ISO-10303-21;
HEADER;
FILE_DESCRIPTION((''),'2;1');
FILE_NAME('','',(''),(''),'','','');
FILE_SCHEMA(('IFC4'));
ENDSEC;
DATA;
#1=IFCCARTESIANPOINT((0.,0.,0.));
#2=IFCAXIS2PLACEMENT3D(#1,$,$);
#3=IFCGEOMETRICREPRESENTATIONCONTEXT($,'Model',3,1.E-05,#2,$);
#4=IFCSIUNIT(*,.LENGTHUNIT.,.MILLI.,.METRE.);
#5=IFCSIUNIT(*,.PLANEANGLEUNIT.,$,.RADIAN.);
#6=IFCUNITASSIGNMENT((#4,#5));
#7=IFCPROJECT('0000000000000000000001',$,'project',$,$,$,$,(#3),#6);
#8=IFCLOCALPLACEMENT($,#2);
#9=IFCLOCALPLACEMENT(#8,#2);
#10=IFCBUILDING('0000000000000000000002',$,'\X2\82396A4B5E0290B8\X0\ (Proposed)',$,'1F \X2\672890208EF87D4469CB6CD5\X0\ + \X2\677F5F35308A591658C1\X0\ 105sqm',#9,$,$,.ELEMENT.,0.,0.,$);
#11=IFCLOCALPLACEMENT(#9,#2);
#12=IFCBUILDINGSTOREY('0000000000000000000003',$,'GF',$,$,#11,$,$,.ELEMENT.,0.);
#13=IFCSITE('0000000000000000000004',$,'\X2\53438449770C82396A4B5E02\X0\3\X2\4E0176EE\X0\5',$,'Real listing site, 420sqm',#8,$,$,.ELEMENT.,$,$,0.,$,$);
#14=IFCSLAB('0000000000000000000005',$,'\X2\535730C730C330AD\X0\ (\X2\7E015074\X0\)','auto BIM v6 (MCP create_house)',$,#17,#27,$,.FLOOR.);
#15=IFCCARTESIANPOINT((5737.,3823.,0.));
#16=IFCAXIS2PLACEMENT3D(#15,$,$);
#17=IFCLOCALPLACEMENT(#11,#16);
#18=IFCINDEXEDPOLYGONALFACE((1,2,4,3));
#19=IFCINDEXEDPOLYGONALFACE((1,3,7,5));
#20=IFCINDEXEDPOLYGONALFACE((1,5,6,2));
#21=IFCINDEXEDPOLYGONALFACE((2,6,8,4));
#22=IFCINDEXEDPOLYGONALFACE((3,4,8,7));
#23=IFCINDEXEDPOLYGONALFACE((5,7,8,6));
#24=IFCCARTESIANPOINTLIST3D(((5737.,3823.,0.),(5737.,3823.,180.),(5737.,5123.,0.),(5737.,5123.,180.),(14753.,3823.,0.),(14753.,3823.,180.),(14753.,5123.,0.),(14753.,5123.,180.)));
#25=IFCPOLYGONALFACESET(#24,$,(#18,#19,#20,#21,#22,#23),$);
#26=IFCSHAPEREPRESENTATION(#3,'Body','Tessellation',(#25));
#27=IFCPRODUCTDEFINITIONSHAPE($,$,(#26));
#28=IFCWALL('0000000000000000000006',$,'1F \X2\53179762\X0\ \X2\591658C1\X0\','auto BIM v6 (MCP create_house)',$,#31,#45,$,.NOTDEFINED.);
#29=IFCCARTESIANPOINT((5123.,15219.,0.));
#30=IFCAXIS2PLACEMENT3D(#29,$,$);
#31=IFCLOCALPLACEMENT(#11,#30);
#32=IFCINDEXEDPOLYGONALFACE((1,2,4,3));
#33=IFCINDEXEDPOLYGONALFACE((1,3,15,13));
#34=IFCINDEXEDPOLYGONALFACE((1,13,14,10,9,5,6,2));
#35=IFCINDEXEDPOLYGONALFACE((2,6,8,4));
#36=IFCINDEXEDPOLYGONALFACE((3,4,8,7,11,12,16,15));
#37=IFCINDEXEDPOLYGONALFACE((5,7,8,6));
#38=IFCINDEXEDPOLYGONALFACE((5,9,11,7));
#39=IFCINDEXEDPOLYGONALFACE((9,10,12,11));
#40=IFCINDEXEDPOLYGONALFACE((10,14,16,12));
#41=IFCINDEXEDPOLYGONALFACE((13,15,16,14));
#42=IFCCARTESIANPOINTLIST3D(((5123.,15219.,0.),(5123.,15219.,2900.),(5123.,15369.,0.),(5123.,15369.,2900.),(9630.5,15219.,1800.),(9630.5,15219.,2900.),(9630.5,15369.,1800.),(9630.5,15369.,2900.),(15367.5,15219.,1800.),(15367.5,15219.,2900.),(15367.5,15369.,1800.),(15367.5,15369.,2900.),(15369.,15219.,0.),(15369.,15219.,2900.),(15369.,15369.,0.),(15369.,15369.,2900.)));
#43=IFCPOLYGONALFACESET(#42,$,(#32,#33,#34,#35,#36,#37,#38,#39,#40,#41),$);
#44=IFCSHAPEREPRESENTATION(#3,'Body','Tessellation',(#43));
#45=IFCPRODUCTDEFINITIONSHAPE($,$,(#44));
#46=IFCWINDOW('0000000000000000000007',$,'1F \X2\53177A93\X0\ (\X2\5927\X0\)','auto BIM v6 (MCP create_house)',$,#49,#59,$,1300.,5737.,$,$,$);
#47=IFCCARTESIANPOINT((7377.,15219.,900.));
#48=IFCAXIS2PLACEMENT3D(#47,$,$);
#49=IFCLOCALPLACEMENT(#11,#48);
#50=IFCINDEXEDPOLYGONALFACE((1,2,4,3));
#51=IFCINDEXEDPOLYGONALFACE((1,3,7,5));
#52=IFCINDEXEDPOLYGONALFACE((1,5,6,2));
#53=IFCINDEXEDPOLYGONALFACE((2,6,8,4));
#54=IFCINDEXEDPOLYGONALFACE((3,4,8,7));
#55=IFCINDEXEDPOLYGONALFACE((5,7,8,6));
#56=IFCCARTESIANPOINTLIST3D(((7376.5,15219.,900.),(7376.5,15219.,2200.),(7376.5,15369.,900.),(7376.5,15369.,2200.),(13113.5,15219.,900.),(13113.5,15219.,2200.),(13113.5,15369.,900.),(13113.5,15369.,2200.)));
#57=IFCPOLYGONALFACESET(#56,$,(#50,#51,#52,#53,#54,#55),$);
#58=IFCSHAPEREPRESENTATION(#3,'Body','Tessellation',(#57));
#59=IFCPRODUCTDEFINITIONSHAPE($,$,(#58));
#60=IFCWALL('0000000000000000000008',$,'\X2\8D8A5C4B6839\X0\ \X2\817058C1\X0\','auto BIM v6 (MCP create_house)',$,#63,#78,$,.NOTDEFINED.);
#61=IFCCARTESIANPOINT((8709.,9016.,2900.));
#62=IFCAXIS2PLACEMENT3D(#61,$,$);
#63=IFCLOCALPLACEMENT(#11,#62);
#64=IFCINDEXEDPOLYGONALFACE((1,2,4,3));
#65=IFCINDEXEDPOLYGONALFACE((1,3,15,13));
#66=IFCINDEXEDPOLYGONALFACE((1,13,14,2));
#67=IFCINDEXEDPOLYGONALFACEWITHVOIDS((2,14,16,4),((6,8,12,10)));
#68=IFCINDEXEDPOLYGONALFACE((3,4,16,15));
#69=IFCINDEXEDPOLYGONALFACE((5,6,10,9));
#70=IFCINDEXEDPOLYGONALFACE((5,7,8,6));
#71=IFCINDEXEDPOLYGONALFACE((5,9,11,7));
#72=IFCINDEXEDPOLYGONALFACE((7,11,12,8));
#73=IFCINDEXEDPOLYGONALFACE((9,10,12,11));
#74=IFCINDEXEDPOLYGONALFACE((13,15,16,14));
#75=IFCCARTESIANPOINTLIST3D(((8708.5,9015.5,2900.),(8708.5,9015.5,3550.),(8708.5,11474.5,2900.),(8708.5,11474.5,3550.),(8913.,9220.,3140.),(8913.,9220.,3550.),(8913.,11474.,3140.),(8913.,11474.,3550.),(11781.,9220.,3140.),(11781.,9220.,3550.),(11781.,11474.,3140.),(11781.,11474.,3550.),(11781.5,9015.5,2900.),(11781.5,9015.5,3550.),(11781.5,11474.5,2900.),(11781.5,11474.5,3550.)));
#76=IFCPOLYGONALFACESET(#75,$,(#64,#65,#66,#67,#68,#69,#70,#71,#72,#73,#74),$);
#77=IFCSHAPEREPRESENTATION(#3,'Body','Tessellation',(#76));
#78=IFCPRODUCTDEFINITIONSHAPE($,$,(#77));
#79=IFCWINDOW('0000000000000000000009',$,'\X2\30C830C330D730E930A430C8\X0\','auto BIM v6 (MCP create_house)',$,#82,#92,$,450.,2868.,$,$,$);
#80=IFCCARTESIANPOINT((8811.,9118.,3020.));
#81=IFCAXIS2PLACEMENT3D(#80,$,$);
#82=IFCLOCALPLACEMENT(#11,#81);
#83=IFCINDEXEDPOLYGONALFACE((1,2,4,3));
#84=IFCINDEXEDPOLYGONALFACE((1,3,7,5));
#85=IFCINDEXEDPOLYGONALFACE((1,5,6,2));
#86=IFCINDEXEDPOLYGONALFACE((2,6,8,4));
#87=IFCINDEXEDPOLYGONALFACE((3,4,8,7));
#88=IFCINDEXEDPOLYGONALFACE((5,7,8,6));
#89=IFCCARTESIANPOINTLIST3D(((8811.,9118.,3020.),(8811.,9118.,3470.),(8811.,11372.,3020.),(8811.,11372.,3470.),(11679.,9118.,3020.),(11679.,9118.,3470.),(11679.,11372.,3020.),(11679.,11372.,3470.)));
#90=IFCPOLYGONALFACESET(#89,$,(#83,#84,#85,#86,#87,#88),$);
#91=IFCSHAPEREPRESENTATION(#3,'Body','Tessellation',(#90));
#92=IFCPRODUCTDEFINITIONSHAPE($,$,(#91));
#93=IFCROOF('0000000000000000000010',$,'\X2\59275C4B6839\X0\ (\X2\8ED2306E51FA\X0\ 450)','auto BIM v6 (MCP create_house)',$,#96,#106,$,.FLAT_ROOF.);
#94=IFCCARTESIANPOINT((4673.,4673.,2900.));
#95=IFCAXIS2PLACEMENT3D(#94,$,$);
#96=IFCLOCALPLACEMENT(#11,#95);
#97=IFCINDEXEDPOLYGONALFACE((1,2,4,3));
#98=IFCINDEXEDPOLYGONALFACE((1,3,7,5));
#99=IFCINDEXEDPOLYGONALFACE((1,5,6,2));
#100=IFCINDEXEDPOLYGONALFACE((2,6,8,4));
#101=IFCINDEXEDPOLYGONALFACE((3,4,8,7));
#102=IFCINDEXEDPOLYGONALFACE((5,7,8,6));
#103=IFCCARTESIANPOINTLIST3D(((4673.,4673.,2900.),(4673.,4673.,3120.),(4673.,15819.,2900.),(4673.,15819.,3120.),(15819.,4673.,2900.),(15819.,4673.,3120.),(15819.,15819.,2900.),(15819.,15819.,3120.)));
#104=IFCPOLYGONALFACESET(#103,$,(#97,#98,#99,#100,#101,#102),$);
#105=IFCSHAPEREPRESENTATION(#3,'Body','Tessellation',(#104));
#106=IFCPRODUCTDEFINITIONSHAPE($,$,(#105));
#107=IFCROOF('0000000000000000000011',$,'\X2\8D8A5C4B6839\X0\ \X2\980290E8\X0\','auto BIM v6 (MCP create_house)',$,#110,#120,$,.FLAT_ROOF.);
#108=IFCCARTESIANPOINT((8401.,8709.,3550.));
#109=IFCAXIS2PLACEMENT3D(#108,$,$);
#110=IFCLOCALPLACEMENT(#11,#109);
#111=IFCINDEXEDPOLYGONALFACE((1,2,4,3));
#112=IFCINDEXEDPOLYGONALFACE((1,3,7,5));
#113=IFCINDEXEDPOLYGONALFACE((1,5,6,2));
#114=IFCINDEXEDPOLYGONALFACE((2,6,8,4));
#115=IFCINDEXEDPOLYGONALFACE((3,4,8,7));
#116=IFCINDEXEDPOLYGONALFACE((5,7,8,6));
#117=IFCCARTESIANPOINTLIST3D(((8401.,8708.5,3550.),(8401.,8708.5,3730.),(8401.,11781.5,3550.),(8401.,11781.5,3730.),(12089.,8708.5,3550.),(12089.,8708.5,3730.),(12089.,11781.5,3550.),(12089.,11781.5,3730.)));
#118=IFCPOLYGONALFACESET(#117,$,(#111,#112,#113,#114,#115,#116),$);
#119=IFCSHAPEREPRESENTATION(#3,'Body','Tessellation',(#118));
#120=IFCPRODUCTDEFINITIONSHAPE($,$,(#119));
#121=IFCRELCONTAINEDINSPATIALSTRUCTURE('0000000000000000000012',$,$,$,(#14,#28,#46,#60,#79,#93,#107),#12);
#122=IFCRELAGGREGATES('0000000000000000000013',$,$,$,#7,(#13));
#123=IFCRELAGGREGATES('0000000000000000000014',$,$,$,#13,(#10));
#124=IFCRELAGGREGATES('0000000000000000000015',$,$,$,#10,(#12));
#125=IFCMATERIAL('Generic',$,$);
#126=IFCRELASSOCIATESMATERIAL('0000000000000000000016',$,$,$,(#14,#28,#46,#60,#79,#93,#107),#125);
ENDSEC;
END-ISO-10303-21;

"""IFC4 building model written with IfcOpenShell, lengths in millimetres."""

from ifc_helpers import new_model, si_unit, frame, frame_2d, origin, place, context, project, spatial, rectangle, extrude, material, element, fill, save


model = new_model("IFC4")

# Units and contexts
model_context = context("Model", 3, precision=1e-05, world=origin())
ifc_project = project(units=[si_unit("LENGTHUNIT", "METRE", prefix="MILLI"), si_unit("PLANEANGLEUNIT", "RADIAN")], contexts=[model_context])

# Site, building, storey
site_placement = place(None, origin())
site = spatial("IfcSite", under=ifc_project, at=site_placement, Name="千葉県船橋市3丁目5", ObjectType="Real listing site, 420sqm", CompositionType="ELEMENT", RefElevation=0.0)
building_placement = place(site_placement, origin())
building = spatial("IfcBuilding", under=site, at=building_placement, Name="船橋市邸 (Proposed)", ObjectType="1F 木造軸組構法 + 板張り外壁 105sqm", CompositionType="ELEMENT", ElevationOfRefHeight=0.0, ElevationOfTerrain=0.0)
storey_placement = place(building_placement, origin())
storey = spatial("IfcBuildingStorey", under=building, at=storey_placement, Name="GF", CompositionType="ELEMENT", Elevation=0.0)

# Slab
ifc_material = material(Name="Generic")
slab_1_placement = place(storey_placement, frame((5737.0, 3823.0, 0.0)))
element("IfcSlab", 1, at=slab_1_placement, inside=storey, material=ifc_material, Name="南デッキ (縁側)", Description="auto BIM v6 (MCP create_house)", PredefinedType="FLOOR", context=model_context, shape_type="SweptSolid", body=[
    extrude(rectangle(XDim=9016.0, YDim=1300.0, at=frame_2d((4508.0, 650.0))), frame((5737.0, 3823.0, 0.0)), (0.0, 0.0, 1.0), 180.0),
])

# Wall, opening, window
wall_1_placement = place(storey_placement, frame((5123.0, 15219.0, 0.0)))
wall_1 = element("IfcWall", 2, at=wall_1_placement, inside=storey, material=ifc_material, Name="1F 北面 外壁", Description="auto BIM v6 (MCP create_house)", PredefinedType="NOTDEFINED", context=model_context, shape_type="SweptSolid", body=[
    extrude(rectangle(XDim=10246.0, YDim=150.0, at=frame_2d((5123.0, 75.0))), frame((5123.0, 15219.0, 0.0)), (0.0, 0.0, 1.0), 2900.0),
])
opening_1_placement = place(storey_placement, frame((7377.0, 15219.0, 900.0)))
opening_1 = element("IfcOpeningElement", 3, at=opening_1_placement, cuts=wall_1, PredefinedType="NOTDEFINED", context=model_context, shape_type="SweptSolid", body=[
    extrude(rectangle(XDim=5737.0, YDim=150.0, at=frame_2d((2868.0, 75.0))), frame((7377.0, 15219.0, 900.0)), (0.0, 0.0, 1.0), 1300.0),
])
window_1_placement = place(storey_placement, frame((7377.0, 15219.0, 900.0)))
window_1 = element("IfcWindow", 4, at=window_1_placement, inside=storey, material=ifc_material, Name="1F 北窓 (大)", Description="auto BIM v6 (MCP create_house)", OverallHeight=1300.0, OverallWidth=5737.0, context=model_context, shape_type="SweptSolid", body=[
    extrude(rectangle(XDim=5737.0, YDim=150.0, at=frame_2d((2868.0, 75.0))), frame((7377.0, 15219.0, 900.0)), (0.0, 0.0, 1.0), 1300.0),
])
fill(opening_1, window_1)

# Wall, opening, window
wall_2_placement = place(storey_placement, frame((8709.0, 9016.0, 2900.0)))
wall_2 = element("IfcWall", 5, at=wall_2_placement, inside=storey, material=ifc_material, Name="越屋根 腰壁", Description="auto BIM v6 (MCP create_house)", PredefinedType="NOTDEFINED", context=model_context, shape_type="SweptSolid", body=[
    extrude(rectangle(XDim=3073.0, YDim=2459.0, at=frame_2d((1536.0, 1229.0))), frame((8709.0, 9016.0, 2900.0)), (0.0, 0.0, 1.0), 650.0),
])
opening_2_placement = place(storey_placement, frame((8811.0, 9118.0, 3020.0)))
opening_2 = element("IfcOpeningElement", 6, at=opening_2_placement, cuts=wall_2, PredefinedType="NOTDEFINED", context=model_context, shape_type="SweptSolid", body=[
    extrude(rectangle(XDim=2868.0, YDim=2254.0, at=frame_2d((1434.0, 1127.0))), frame((8811.0, 9118.0, 3020.0)), (0.0, 0.0, 1.0), 450.0),
])
window_2_placement = place(storey_placement, frame((8811.0, 9118.0, 3020.0)))
window_2 = element("IfcWindow", 7, at=window_2_placement, inside=storey, material=ifc_material, Name="トップライト", Description="auto BIM v6 (MCP create_house)", OverallHeight=450.0, OverallWidth=2868.0, context=model_context, shape_type="SweptSolid", body=[
    extrude(rectangle(XDim=2868.0, YDim=2254.0, at=frame_2d((1434.0, 1127.0))), frame((8811.0, 9118.0, 3020.0)), (0.0, 0.0, 1.0), 450.0),
])
fill(opening_2, window_2)

# Roofs
roof_1_placement = place(storey_placement, frame((4673.0, 4673.0, 2900.0)))
element("IfcRoof", 8, at=roof_1_placement, inside=storey, material=ifc_material, Name="大屋根 (軒の出 450)", Description="auto BIM v6 (MCP create_house)", PredefinedType="FLAT_ROOF", context=model_context, shape_type="SweptSolid", body=[
    extrude(rectangle(XDim=11146.0, YDim=11146.0, at=frame_2d((5573.0, 5573.0))), frame((4673.0, 4673.0, 2900.0)), (0.0, 0.0, 1.0), 220.0),
])
roof_2_placement = place(storey_placement, frame((8401.0, 8709.0, 3550.0)))
element("IfcRoof", 9, at=roof_2_placement, inside=storey, material=ifc_material, Name="越屋根 頂部", Description="auto BIM v6 (MCP create_house)", PredefinedType="FLAT_ROOF", context=model_context, shape_type="SweptSolid", body=[
    extrude(rectangle(XDim=3688.0, YDim=3073.0, at=frame_2d((1844.0, 1536.0))), frame((8401.0, 8709.0, 3550.0)), (0.0, 0.0, 1.0), 180.0),
])

save(model, "model.ifc")
